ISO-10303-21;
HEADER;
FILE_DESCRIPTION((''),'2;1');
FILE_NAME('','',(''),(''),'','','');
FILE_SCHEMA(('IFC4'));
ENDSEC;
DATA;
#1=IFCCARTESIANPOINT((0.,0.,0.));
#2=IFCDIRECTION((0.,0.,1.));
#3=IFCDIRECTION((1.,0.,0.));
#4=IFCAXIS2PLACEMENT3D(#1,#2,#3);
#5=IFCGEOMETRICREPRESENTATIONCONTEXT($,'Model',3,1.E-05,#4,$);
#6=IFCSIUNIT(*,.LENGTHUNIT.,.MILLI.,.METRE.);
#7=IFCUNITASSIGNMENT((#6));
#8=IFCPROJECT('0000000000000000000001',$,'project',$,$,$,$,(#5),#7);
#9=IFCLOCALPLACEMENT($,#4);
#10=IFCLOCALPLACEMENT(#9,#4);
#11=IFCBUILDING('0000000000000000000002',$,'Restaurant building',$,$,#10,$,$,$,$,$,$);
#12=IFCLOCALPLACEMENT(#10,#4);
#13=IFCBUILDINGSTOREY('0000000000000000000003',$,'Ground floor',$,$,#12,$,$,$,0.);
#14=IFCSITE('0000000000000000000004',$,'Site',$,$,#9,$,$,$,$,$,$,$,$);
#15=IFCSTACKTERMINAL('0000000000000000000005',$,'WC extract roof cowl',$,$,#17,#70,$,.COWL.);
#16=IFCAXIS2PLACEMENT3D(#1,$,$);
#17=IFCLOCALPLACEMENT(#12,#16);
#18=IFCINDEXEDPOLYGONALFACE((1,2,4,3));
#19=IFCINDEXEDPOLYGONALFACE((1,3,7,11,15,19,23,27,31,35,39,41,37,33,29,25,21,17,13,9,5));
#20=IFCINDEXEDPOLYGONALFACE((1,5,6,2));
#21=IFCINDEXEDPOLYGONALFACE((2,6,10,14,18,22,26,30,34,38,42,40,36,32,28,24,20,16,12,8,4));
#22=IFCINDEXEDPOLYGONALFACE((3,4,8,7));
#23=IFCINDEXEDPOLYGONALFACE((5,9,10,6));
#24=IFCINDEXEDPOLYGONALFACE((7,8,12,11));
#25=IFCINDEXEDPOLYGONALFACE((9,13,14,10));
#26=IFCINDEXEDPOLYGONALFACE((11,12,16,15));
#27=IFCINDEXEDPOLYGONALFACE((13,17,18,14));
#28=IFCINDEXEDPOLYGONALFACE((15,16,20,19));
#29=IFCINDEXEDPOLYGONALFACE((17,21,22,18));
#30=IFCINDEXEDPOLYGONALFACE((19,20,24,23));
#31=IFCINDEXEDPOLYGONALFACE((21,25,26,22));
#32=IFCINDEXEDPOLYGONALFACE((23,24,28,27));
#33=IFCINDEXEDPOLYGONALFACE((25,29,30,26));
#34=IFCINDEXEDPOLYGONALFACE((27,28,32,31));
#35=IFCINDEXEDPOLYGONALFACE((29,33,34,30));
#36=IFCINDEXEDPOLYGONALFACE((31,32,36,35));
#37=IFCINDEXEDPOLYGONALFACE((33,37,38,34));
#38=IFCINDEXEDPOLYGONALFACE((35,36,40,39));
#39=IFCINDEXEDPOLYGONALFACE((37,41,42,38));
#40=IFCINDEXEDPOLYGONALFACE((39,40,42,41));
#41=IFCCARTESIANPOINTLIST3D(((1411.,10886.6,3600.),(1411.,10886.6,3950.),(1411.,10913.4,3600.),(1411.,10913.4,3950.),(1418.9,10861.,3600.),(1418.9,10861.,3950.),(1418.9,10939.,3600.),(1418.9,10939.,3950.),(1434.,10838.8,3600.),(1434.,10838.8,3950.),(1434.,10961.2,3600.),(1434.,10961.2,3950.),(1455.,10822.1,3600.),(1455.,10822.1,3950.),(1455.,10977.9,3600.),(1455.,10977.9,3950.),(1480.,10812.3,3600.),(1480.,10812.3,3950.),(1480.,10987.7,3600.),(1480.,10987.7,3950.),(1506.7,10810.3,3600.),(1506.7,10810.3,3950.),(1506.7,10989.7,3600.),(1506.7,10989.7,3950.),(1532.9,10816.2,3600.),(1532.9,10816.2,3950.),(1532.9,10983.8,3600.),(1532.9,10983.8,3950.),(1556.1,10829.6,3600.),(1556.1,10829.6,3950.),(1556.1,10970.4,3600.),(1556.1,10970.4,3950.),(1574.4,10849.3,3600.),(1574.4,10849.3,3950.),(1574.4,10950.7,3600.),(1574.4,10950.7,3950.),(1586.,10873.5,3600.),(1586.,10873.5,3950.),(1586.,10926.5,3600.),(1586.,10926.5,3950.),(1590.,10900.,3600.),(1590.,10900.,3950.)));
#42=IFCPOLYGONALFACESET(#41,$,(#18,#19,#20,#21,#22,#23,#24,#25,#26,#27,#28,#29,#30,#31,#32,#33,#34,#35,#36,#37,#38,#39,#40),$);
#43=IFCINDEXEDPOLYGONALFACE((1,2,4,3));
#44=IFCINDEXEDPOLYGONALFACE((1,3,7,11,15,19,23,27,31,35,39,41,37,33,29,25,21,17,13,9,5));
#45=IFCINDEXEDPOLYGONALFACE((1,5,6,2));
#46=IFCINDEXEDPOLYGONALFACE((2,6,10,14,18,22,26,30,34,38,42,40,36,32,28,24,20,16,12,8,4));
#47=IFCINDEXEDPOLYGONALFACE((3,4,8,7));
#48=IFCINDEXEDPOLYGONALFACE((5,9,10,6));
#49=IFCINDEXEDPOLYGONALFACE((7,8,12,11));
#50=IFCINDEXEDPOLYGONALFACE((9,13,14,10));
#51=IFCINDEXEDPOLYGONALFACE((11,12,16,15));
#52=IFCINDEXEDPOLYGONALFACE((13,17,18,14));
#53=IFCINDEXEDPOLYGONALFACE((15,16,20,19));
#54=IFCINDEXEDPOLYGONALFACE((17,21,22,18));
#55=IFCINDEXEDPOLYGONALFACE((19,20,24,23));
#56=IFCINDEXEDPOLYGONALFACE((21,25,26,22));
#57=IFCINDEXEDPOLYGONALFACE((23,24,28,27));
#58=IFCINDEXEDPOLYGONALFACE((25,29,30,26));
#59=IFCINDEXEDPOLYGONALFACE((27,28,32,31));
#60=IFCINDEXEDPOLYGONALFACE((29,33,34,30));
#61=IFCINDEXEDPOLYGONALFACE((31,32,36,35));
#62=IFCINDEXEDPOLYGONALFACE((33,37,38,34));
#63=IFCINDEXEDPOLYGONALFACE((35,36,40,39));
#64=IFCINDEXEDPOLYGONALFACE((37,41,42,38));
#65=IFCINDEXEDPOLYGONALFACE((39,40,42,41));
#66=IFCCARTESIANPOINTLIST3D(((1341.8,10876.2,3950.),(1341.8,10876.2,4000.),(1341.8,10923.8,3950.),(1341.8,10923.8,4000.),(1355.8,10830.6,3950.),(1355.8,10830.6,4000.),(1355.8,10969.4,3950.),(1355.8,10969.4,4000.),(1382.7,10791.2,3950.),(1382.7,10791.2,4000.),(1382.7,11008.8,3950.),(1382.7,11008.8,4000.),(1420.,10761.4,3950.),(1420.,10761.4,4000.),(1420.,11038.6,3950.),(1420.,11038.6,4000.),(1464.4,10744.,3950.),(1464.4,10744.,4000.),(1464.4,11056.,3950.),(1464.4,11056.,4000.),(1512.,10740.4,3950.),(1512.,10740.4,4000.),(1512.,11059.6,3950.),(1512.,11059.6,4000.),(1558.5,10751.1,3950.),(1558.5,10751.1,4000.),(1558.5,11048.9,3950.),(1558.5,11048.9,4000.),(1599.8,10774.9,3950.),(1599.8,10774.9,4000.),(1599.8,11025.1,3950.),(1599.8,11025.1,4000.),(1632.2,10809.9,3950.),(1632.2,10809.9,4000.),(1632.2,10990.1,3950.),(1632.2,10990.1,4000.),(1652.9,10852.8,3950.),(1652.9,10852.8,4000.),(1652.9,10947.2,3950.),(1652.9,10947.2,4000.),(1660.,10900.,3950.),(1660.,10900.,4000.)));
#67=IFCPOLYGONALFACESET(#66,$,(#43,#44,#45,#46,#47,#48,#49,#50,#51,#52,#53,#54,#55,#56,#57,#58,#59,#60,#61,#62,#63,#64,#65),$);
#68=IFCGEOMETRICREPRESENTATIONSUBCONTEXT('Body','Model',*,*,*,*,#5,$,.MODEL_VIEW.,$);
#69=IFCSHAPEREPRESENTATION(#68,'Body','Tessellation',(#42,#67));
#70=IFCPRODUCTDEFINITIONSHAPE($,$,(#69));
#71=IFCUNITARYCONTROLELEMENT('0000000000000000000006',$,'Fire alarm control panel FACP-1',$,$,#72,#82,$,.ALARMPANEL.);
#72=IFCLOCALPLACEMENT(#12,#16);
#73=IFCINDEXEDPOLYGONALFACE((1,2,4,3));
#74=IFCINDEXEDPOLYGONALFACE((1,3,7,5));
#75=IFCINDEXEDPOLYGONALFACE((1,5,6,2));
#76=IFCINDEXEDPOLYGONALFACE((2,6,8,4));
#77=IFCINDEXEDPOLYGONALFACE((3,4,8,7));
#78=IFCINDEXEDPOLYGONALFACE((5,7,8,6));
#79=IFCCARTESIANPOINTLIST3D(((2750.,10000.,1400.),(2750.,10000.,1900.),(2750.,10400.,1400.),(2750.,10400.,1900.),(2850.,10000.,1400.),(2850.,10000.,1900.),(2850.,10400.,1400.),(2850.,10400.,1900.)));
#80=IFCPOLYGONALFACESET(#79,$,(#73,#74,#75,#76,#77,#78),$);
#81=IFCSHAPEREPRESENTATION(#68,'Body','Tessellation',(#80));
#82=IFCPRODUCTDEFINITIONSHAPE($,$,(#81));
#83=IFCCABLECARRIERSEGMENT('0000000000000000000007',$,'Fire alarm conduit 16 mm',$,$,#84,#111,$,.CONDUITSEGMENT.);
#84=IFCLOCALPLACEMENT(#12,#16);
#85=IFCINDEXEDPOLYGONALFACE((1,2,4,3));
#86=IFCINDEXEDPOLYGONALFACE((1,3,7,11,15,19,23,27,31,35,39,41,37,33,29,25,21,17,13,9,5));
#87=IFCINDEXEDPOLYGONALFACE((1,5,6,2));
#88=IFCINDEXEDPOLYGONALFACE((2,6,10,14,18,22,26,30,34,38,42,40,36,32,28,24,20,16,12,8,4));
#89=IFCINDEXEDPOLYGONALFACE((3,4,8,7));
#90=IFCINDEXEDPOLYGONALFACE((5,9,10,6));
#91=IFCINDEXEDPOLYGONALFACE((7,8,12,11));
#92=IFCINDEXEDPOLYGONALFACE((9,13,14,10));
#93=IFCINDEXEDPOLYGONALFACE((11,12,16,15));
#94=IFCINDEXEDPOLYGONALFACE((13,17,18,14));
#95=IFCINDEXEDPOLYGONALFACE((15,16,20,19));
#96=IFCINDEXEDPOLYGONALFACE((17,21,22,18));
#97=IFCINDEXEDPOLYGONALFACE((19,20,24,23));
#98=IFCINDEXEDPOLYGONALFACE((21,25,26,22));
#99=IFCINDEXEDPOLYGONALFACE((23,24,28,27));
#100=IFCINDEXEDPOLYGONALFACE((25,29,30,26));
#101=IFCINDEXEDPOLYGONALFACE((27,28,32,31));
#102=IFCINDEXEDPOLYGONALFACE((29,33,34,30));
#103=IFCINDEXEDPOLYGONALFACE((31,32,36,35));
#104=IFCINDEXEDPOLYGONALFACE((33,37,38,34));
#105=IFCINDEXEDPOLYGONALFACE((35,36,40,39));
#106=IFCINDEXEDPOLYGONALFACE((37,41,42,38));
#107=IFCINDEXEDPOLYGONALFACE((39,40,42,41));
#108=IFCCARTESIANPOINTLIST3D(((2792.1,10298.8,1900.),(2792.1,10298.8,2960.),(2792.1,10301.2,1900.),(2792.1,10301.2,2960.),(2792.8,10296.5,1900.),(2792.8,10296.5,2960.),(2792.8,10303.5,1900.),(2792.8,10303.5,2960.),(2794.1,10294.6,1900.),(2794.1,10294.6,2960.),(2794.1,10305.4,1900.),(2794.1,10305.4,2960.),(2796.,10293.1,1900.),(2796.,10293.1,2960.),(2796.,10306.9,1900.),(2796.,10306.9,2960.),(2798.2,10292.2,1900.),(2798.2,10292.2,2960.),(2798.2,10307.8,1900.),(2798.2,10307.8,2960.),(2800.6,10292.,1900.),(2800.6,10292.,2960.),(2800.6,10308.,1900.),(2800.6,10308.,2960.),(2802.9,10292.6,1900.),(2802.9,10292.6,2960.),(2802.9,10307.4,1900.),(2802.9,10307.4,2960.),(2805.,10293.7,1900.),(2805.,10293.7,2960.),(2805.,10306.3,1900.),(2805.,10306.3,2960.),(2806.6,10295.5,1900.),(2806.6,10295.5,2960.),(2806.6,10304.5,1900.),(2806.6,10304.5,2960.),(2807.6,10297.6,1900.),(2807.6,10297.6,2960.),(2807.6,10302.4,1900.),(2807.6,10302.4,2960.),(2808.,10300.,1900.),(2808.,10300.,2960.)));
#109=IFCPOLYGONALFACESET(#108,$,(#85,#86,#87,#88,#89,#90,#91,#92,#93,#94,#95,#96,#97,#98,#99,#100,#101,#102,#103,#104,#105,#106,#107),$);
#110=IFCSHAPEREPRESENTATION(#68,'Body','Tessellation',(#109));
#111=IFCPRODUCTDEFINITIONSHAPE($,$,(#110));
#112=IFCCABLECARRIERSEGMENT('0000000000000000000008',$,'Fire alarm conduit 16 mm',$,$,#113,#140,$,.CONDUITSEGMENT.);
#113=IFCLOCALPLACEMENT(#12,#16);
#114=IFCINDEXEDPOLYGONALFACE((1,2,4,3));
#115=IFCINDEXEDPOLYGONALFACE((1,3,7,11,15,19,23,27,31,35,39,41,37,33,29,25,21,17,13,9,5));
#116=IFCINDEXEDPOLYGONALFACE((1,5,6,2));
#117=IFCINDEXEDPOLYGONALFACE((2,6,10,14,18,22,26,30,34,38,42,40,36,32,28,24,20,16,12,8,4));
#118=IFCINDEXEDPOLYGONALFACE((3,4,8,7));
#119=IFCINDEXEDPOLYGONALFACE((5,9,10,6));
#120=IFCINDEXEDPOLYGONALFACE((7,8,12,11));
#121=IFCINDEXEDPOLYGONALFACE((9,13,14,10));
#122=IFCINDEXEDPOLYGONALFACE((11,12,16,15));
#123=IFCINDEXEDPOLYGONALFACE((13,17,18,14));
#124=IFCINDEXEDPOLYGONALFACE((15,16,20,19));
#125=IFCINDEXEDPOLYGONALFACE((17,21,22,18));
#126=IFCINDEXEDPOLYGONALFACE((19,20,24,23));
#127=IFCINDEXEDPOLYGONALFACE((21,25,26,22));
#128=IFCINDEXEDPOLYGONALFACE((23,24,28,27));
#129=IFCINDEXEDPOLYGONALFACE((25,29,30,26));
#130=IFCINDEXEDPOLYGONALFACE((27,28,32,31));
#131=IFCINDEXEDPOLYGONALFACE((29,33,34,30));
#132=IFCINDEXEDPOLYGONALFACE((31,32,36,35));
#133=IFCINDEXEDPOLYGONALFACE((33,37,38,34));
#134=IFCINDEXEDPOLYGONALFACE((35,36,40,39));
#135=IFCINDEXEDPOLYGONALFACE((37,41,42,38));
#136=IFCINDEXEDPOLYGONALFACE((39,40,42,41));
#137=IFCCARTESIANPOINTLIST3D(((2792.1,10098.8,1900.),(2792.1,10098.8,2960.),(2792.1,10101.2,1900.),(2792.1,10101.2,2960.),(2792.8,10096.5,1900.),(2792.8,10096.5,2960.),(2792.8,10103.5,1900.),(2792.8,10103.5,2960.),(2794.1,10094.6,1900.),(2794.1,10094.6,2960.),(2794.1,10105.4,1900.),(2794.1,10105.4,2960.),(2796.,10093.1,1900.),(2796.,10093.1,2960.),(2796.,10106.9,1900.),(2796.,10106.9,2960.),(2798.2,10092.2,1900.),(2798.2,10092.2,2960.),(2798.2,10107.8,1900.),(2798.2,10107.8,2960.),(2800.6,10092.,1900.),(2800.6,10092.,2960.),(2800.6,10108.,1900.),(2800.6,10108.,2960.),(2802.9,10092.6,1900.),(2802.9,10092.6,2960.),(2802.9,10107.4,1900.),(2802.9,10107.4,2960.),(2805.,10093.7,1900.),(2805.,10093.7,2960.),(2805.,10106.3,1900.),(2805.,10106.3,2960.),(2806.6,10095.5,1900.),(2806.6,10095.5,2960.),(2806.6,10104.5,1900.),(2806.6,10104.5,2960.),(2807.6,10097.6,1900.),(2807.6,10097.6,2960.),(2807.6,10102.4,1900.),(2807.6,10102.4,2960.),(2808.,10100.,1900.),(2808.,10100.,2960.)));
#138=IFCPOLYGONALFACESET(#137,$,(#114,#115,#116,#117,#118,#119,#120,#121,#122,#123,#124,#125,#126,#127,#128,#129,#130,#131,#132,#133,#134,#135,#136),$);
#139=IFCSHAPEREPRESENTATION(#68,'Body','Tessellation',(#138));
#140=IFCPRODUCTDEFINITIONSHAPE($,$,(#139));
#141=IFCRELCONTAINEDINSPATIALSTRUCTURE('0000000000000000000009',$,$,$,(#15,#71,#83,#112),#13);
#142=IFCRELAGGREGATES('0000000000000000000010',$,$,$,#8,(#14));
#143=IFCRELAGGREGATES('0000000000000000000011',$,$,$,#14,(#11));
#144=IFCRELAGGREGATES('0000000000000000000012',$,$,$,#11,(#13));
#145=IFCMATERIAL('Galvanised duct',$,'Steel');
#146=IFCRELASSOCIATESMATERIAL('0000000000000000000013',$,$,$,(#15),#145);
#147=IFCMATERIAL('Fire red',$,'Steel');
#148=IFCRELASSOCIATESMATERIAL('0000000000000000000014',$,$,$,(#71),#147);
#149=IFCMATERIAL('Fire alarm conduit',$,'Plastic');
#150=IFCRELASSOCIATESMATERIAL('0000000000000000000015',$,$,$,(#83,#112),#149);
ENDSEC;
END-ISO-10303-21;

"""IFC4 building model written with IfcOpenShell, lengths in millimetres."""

from ifc_helpers import new_model, si_unit, frame, origin, origin_with_axes, origin_2d, place, context, subcontext, project, spatial, rectangle, circle, extrude, material, element, save


model = new_model("IFC4")

# Units and contexts
model_context = context("Model", 3, precision=1e-05, world=origin_with_axes())
body_context = subcontext(model_context, "Body", "Model", "MODEL_VIEW")
ifc_project = project(units=[si_unit("LENGTHUNIT", "METRE", prefix="MILLI")], contexts=[model_context])

# Site, building, storey
site_placement = place(None, origin_with_axes())
site = spatial("IfcSite", under=ifc_project, at=site_placement, Name="Site")
building_placement = place(site_placement, origin_with_axes())
building = spatial("IfcBuilding", under=site, at=building_placement, Name="Restaurant building")
storey_placement = place(building_placement, origin_with_axes())
storey = spatial("IfcBuildingStorey", under=building, at=storey_placement, Name="Ground floor", Elevation=0.0)

# Stack terminal
ifc_material_1 = material(Name="Galvanised duct", Category="Steel")
stack_terminal_1_placement = place(storey_placement, frame((1500.0, 10900.0, 0.0)))
element("IfcStackTerminal", 1, at=stack_terminal_1_placement, inside=storey, material=ifc_material_1, Name="WC extract roof cowl", PredefinedType="COWL", context=body_context, shape_type="SweptSolid", body=[
    extrude(circle(Radius=90.0, at=origin_2d()), frame((0.0, 0.0, 3600.0)), (0.0, 0.0, 1.0), 350.0),
    extrude(circle(Radius=160.0, at=origin_2d()), frame((0.0, 0.0, 3950.0)), (0.0, 0.0, 1.0), 50.0),
])

# Unitary control element
ifc_material_2 = material(Name="Fire red", Category="Steel")
unitary_control_element_placement = place(storey_placement, frame((2800.0, 10200.0, 0.0)))
element("IfcUnitaryControlElement", 2, at=unitary_control_element_placement, inside=storey, material=ifc_material_2, Name="Fire alarm control panel FACP-1", PredefinedType="ALARMPANEL", context=body_context, shape_type="SweptSolid", body=[
    extrude(rectangle(XDim=100.0, YDim=400.0, at=origin_2d()), frame((0.0, 0.0, 1400.0)), (0.0, 0.0, 1.0), 500.0),
])

# Cable carrier segments
ifc_material_3 = material(Name="Fire alarm conduit", Category="Plastic")
for number, where, name in (
    (3, (2800.0, 10300.0, 1900.0), "Fire alarm conduit 16 mm"),
    (4, (2800.0, 10100.0, 1900.0), "Fire alarm conduit 16 mm"),
):
    element("IfcCableCarrierSegment", number, at=place(storey_placement, frame(where)), inside=storey, material=ifc_material_3, Name=name, PredefinedType="CONDUITSEGMENT", context=body_context, shape_type="SweptSolid", body=[
        extrude(circle(Radius=8.0, at=origin_2d()), origin(), (0.0, 0.0, 1.0), 1060.0),
    ])

save(model, "model.ifc")
